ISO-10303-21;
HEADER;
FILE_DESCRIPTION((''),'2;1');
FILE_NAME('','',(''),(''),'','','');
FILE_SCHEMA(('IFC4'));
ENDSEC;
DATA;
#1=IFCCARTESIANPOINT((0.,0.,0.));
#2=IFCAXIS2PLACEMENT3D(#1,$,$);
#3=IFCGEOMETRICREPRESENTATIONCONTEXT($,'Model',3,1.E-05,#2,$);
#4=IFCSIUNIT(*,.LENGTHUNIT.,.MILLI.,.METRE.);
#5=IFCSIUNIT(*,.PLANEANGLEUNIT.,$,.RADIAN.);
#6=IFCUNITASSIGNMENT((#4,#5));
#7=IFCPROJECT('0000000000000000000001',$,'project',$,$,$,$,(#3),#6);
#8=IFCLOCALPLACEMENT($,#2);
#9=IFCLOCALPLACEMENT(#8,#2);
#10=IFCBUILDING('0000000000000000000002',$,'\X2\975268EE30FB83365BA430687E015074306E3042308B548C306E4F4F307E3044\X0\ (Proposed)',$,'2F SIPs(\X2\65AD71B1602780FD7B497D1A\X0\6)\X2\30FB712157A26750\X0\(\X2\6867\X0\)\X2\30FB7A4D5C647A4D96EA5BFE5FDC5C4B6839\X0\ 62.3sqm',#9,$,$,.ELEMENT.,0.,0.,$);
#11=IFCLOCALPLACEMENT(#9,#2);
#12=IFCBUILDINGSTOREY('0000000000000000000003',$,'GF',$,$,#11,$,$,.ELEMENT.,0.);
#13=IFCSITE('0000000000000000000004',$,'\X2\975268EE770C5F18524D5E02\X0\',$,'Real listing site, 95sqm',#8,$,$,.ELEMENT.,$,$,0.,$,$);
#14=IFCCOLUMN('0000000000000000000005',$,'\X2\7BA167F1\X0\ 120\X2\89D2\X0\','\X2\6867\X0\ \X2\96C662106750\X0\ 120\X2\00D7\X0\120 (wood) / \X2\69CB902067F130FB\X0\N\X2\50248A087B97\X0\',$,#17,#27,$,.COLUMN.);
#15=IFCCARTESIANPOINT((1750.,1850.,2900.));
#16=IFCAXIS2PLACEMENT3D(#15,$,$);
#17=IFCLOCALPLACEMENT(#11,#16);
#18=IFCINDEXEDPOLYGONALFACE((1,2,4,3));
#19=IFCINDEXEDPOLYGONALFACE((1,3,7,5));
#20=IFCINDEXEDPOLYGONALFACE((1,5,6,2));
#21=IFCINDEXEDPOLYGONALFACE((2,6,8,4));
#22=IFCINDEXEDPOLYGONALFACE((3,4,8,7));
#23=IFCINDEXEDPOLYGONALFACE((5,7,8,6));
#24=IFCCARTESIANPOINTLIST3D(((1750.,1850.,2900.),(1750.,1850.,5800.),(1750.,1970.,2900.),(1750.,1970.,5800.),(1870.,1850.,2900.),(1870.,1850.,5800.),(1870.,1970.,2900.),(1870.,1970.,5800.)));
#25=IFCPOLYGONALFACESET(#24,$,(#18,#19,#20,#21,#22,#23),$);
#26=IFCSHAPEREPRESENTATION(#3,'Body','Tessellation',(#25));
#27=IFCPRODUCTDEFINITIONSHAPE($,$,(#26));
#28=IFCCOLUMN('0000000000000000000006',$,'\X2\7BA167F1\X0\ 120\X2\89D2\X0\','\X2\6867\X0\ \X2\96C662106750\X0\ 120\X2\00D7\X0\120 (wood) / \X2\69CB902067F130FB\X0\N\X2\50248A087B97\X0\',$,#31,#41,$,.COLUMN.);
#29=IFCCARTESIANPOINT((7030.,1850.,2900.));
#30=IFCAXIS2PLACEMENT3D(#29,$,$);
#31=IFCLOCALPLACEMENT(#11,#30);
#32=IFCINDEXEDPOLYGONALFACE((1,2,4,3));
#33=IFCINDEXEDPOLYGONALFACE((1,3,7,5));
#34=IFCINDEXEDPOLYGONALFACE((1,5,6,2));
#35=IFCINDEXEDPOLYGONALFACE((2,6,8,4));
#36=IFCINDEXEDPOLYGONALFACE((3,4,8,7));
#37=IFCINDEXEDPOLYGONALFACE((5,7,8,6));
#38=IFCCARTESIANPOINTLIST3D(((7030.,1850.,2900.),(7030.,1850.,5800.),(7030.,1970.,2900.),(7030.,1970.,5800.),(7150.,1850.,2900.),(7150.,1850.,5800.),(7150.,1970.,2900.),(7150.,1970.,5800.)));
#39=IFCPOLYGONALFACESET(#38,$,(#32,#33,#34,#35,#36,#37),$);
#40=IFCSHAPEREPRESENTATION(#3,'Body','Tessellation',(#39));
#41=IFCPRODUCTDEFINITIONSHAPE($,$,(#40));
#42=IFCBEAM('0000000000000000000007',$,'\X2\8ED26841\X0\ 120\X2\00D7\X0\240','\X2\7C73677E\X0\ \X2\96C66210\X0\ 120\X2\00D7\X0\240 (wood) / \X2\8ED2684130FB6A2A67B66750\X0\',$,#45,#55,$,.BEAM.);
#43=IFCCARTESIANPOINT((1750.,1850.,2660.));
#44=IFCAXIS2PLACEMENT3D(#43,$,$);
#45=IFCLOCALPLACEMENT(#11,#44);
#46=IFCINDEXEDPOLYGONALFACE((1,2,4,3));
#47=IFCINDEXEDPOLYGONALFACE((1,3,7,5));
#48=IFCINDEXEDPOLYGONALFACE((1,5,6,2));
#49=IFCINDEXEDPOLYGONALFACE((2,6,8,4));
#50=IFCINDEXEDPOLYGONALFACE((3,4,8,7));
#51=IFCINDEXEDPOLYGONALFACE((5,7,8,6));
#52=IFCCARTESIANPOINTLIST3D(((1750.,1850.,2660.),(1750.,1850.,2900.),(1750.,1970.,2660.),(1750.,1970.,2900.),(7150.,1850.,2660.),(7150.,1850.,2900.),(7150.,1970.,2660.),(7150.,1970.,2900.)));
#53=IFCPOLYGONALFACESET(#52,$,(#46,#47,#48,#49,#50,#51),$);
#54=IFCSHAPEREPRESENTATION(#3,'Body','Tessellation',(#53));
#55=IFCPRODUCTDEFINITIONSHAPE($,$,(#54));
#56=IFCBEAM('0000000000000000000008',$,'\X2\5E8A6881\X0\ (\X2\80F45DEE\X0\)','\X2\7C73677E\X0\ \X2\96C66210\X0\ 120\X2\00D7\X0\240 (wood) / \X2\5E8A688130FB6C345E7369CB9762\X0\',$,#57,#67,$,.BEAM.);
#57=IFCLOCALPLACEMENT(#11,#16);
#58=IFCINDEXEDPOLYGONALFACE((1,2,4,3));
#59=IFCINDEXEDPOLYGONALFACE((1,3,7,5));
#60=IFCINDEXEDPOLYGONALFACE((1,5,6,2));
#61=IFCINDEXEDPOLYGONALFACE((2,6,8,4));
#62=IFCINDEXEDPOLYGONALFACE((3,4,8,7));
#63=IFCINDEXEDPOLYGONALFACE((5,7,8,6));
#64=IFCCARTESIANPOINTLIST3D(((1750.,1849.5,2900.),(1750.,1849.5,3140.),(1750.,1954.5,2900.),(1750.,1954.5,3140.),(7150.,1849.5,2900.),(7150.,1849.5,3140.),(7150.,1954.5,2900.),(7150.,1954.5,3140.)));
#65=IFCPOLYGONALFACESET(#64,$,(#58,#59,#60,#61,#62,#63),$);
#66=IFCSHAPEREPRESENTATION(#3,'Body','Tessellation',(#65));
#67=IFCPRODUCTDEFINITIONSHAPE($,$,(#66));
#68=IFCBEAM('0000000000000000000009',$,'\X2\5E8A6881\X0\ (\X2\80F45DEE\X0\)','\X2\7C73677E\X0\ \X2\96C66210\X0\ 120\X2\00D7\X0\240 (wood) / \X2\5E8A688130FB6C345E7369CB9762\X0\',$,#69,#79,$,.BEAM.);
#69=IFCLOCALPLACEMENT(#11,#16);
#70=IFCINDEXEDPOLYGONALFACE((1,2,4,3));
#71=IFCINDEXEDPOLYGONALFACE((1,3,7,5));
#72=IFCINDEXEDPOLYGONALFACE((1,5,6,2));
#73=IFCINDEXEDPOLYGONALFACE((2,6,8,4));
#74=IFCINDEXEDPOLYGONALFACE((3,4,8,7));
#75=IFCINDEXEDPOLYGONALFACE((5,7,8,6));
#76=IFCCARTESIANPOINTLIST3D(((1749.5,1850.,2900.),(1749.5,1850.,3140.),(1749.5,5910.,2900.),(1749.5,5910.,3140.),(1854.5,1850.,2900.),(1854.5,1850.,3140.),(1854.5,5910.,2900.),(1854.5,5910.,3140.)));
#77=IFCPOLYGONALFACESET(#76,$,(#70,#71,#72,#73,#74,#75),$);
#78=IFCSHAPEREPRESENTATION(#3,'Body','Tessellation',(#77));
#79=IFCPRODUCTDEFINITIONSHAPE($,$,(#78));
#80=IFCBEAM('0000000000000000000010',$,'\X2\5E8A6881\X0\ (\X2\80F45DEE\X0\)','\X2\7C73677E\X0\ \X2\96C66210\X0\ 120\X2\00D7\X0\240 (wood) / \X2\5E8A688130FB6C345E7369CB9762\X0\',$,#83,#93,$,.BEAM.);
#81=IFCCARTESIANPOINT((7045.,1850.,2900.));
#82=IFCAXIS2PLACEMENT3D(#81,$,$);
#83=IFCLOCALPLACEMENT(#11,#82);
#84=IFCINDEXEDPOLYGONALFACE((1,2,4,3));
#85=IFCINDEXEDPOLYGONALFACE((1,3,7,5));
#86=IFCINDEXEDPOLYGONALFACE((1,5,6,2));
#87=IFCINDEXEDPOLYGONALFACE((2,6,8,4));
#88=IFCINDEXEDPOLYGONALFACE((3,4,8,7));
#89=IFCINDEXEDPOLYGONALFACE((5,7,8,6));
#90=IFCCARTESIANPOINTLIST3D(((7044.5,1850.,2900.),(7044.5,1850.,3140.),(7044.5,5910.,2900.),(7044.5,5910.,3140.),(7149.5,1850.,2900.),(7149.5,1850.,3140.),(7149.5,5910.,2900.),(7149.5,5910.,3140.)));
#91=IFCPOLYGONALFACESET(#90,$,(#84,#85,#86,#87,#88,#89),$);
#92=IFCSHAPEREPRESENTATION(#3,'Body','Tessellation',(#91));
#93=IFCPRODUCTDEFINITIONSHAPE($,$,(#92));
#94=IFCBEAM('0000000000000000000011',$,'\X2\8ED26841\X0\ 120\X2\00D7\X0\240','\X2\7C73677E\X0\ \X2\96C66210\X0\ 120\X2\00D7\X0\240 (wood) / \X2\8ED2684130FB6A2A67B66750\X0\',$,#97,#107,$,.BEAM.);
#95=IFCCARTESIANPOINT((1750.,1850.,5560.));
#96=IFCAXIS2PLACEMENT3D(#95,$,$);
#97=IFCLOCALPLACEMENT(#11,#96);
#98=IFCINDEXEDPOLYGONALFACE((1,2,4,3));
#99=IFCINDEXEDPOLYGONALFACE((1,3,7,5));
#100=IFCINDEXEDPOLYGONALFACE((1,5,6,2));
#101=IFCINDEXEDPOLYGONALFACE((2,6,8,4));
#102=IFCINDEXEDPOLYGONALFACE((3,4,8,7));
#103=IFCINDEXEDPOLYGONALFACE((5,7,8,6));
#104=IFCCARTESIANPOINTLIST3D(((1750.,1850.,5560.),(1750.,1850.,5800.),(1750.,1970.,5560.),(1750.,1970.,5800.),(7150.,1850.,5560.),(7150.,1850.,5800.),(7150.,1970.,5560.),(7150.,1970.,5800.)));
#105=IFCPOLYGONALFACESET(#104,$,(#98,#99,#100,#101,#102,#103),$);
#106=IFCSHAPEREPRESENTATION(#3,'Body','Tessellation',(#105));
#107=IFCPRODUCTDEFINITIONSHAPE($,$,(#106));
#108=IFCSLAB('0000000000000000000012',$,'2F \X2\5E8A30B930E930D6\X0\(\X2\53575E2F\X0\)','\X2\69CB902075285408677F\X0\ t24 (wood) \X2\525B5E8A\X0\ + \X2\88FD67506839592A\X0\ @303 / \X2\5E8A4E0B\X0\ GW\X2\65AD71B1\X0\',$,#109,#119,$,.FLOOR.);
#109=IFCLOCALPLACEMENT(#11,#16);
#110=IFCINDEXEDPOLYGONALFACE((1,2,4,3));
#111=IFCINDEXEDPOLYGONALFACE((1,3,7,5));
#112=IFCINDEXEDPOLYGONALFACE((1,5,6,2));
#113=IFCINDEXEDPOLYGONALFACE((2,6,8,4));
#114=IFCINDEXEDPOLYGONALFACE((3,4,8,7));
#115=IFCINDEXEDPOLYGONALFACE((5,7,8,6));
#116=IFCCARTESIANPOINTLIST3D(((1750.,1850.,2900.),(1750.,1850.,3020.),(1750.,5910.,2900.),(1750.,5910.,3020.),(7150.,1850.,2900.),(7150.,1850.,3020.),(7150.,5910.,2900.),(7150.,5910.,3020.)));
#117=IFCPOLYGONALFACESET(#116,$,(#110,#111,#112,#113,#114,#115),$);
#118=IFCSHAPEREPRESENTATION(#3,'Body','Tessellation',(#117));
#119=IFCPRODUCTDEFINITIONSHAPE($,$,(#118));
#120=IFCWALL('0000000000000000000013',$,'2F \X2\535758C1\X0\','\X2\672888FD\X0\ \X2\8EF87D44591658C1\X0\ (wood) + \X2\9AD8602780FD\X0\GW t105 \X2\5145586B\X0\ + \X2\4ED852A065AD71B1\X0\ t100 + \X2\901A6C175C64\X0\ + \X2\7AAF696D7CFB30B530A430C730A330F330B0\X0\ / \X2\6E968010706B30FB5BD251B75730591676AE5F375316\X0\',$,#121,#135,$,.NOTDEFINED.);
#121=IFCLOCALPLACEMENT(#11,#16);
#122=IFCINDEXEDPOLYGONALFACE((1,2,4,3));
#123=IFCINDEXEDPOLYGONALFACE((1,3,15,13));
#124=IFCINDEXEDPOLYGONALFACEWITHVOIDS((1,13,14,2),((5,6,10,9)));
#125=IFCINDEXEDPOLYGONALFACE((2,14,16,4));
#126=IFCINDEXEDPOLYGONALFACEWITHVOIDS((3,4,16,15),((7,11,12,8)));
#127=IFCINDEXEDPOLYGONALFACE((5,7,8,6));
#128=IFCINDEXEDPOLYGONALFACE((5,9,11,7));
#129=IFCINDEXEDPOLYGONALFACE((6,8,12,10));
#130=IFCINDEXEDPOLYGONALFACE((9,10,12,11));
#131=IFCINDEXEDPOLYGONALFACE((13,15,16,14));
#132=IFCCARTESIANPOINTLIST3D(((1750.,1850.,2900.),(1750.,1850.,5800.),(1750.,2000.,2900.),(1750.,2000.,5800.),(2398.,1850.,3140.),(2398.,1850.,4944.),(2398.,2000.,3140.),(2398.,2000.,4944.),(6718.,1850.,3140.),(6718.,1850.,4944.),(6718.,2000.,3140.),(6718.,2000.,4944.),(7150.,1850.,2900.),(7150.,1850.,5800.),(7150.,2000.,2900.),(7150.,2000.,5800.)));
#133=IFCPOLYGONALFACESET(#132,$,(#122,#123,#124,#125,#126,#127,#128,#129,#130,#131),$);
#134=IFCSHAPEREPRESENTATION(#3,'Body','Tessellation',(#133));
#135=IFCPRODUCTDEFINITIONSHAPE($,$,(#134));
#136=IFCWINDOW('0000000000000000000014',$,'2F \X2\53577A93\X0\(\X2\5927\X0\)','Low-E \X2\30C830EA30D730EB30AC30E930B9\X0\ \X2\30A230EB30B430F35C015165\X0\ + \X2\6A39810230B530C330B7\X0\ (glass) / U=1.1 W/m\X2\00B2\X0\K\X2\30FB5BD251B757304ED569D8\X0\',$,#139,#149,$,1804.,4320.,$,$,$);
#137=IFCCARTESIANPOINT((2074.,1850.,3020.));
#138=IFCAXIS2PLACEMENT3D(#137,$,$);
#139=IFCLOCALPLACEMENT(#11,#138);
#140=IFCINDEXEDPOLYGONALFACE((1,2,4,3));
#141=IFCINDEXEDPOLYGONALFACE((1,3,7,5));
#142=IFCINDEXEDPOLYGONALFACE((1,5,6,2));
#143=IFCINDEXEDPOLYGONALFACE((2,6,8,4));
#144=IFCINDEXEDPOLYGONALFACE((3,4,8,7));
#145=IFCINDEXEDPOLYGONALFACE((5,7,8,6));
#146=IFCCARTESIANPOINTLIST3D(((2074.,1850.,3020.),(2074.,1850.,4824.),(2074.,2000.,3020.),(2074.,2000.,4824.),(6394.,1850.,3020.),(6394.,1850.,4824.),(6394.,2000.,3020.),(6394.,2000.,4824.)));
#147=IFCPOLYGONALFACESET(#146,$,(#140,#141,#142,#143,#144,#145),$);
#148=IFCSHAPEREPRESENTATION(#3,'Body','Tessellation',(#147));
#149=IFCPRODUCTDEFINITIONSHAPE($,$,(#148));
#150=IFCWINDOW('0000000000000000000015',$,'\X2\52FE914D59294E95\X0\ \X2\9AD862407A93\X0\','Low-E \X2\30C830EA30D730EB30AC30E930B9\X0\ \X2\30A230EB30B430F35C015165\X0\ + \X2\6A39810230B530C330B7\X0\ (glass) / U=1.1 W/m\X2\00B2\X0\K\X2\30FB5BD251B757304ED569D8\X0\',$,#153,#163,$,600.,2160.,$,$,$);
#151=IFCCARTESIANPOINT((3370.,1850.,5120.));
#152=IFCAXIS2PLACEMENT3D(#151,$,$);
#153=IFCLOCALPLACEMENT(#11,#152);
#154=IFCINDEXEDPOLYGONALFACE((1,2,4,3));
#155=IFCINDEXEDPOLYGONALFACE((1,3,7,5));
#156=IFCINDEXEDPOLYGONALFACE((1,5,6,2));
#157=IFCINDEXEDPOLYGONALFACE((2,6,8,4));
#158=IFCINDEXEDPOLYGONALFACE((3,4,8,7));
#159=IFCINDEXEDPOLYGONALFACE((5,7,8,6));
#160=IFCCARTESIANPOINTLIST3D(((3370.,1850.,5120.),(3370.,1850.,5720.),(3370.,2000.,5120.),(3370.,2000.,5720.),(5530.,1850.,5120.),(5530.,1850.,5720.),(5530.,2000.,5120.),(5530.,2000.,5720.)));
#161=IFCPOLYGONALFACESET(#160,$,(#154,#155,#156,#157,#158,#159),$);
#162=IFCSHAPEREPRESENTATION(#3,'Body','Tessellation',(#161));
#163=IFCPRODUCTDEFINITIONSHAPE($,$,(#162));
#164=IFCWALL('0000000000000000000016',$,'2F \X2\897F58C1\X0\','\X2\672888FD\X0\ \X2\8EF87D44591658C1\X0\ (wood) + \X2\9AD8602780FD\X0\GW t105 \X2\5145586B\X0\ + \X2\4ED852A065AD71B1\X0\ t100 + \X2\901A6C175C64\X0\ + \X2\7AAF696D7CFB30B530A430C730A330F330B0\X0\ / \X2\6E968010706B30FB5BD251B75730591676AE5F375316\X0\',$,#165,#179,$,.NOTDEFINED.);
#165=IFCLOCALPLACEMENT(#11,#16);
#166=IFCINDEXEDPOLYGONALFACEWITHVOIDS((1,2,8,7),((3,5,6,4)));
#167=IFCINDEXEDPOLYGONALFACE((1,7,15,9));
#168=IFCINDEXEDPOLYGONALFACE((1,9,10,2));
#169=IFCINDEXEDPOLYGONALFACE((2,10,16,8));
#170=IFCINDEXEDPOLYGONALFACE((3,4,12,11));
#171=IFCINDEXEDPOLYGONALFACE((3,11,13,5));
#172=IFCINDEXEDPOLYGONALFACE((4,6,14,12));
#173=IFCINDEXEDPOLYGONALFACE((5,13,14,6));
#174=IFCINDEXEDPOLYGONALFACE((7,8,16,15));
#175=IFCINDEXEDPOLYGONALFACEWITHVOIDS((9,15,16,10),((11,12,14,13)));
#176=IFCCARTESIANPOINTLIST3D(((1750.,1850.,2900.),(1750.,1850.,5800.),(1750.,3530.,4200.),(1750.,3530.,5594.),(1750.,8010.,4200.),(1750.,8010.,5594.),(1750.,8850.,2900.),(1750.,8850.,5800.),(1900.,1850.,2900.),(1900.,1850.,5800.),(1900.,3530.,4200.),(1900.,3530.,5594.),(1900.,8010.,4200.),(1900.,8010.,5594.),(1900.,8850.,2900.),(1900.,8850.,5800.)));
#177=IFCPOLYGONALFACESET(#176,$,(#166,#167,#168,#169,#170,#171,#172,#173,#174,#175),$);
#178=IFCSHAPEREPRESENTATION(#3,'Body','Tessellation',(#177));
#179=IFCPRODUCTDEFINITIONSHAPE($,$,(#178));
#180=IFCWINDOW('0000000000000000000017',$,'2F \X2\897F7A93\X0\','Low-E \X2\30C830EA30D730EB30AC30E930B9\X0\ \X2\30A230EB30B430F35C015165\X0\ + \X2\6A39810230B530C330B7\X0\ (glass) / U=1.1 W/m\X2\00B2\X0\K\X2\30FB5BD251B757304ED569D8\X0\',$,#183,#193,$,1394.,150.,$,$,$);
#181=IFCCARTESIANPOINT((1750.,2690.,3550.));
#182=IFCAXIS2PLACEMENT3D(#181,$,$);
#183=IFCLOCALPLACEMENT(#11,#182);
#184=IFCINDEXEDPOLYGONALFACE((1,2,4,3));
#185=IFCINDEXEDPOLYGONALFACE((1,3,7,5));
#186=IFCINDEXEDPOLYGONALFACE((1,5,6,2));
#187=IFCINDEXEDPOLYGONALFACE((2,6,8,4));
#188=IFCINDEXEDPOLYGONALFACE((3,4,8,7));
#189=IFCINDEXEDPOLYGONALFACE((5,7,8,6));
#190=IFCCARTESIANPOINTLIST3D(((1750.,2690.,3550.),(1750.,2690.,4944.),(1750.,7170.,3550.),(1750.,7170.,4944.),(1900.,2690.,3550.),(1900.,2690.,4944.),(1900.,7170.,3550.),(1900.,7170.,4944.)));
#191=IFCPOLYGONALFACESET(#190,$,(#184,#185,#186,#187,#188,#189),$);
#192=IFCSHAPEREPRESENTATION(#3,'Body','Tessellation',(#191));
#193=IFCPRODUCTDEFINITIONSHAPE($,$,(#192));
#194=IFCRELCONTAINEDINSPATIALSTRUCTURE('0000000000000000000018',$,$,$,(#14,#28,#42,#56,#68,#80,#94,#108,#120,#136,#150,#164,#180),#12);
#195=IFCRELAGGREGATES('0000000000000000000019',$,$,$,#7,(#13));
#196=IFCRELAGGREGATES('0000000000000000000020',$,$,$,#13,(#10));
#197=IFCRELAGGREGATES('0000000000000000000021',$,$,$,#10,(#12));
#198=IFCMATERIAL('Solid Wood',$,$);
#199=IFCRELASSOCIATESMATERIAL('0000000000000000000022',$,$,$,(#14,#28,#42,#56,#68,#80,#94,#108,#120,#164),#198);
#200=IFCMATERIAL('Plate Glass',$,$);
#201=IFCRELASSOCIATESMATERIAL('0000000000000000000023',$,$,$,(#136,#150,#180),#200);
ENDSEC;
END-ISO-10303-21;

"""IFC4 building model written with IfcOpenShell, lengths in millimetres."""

from ifc_helpers import new_model, si_unit, frame, frame_2d, origin, place, context, project, spatial, rectangle, extrude, material, element, fill, save


model = new_model("IFC4")

# Units and contexts
model_context = context("Model", 3, precision=1e-05, world=origin())
ifc_project = project(units=[si_unit("LENGTHUNIT", "METRE", prefix="MILLI"), si_unit("PLANEANGLEUNIT", "RADIAN")], contexts=[model_context])

# Site, building, storey
site_placement = place(None, origin())
site = spatial("IfcSite", under=ifc_project, at=site_placement, Name="青森県弘前市", ObjectType="Real listing site, 95sqm", CompositionType="ELEMENT", RefElevation=0.0)
building_placement = place(site_placement, origin())
building = spatial("IfcBuilding", under=site, at=building_placement, Name="青森・茶室と縁側のある和の住まい (Proposed)", ObjectType="2F SIPs(断熱性能等級6)・無垢材(桧)・積層積雪対応屋根 62.3sqm", CompositionType="ELEMENT", ElevationOfRefHeight=0.0, ElevationOfTerrain=0.0)
storey_placement = place(building_placement, origin())
storey = spatial("IfcBuildingStorey", under=building, at=storey_placement, Name="GF", CompositionType="ELEMENT", Elevation=0.0)

# Columns
ifc_material_1 = material(Name="Solid Wood")
column_1_placement = place(storey_placement, frame((1750.0, 1850.0, 2900.0)))
element("IfcColumn", 1, at=column_1_placement, inside=storey, material=ifc_material_1, Name="管柱 120角", Description="桧 集成材 120×120 (wood) / 構造柱・N値計算", PredefinedType="COLUMN", context=model_context, shape_type="SweptSolid", body=[
    extrude(rectangle(XDim=120.0, YDim=120.0, at=frame_2d((60.0, 60.0))), frame((1750.0, 1850.0, 2900.0)), (0.0, 0.0, 1.0), 2900.0),
])
column_2_placement = place(storey_placement, frame((7030.0, 1850.0, 2900.0)))
element("IfcColumn", 2, at=column_2_placement, inside=storey, material=ifc_material_1, Name="管柱 120角", Description="桧 集成材 120×120 (wood) / 構造柱・N値計算", PredefinedType="COLUMN", context=model_context, shape_type="SweptSolid", body=[
    extrude(rectangle(XDim=120.0, YDim=120.0, at=frame_2d((60.0, 60.0))), frame((7030.0, 1850.0, 2900.0)), (0.0, 0.0, 1.0), 2900.0),
])

# Beams
beam_1_placement = place(storey_placement, frame((1750.0, 1850.0, 2660.0)))
element("IfcBeam", 3, at=beam_1_placement, inside=storey, material=ifc_material_1, Name="軒桁 120×240", Description="米松 集成 120×240 (wood) / 軒桁・横架材", PredefinedType="BEAM", context=model_context, shape_type="SweptSolid", body=[
    extrude(rectangle(XDim=5400.0, YDim=120.0, at=frame_2d((2700.0, 60.0))), frame((1750.0, 1850.0, 2660.0)), (0.0, 0.0, 1.0), 240.0),
])
beam_2_placement = place(storey_placement, frame((1750.0, 1850.0, 2900.0)))
element("IfcBeam", 4, at=beam_2_placement, inside=storey, material=ifc_material_1, Name="床梁 (胴差)", Description="米松 集成 120×240 (wood) / 床梁・水平構面", PredefinedType="BEAM", context=model_context, shape_type="SweptSolid", body=[
    extrude(rectangle(XDim=5400.0, YDim=105.0, at=frame_2d((2700.0, 52.0))), frame((1750.0, 1850.0, 2900.0)), (0.0, 0.0, 1.0), 240.0),
])
beam_3_placement = place(storey_placement, frame((1750.0, 1850.0, 2900.0)))
element("IfcBeam", 5, at=beam_3_placement, inside=storey, material=ifc_material_1, Name="床梁 (胴差)", Description="米松 集成 120×240 (wood) / 床梁・水平構面", PredefinedType="BEAM", context=model_context, shape_type="SweptSolid", body=[
    extrude(rectangle(XDim=105.0, YDim=4060.0, at=frame_2d((52.0, 2030.0))), frame((1750.0, 1850.0, 2900.0)), (0.0, 0.0, 1.0), 240.0),
])
beam_4_placement = place(storey_placement, frame((7045.0, 1850.0, 2900.0)))
element("IfcBeam", 6, at=beam_4_placement, inside=storey, material=ifc_material_1, Name="床梁 (胴差)", Description="米松 集成 120×240 (wood) / 床梁・水平構面", PredefinedType="BEAM", context=model_context, shape_type="SweptSolid", body=[
    extrude(rectangle(XDim=105.0, YDim=4060.0, at=frame_2d((52.0, 2030.0))), frame((7045.0, 1850.0, 2900.0)), (0.0, 0.0, 1.0), 240.0),
])
beam_5_placement = place(storey_placement, frame((1750.0, 1850.0, 5560.0)))
element("IfcBeam", 7, at=beam_5_placement, inside=storey, material=ifc_material_1, Name="軒桁 120×240", Description="米松 集成 120×240 (wood) / 軒桁・横架材", PredefinedType="BEAM", context=model_context, shape_type="SweptSolid", body=[
    extrude(rectangle(XDim=5400.0, YDim=120.0, at=frame_2d((2700.0, 60.0))), frame((1750.0, 1850.0, 5560.0)), (0.0, 0.0, 1.0), 240.0),
])

# Slab
slab_placement = place(storey_placement, frame((1750.0, 1850.0, 2900.0)))
element("IfcSlab", 8, at=slab_placement, inside=storey, material=ifc_material_1, Name="2F 床スラブ(南帯)", Description="構造用合板 t24 (wood) 剛床 + 製材根太 @303 / 床下 GW断熱", PredefinedType="FLOOR", context=model_context, shape_type="SweptSolid", body=[
    extrude(rectangle(XDim=5400.0, YDim=4060.0, at=frame_2d((2700.0, 2030.0))), frame((1750.0, 1850.0, 2900.0)), (0.0, 0.0, 1.0), 120.0),
])

# Wall, openings, windows
wall_1_placement = place(storey_placement, frame((1750.0, 1850.0, 2900.0)))
wall_1 = element("IfcWall", 9, at=wall_1_placement, inside=storey, material=ifc_material_1, Name="2F 南壁", Description="木製 軸組外壁 (wood) + 高性能GW t105 充填 + 付加断熱 t100 + 通気層 + 窯業系サイディング / 準耐火・寒冷地外皮強化", PredefinedType="NOTDEFINED", context=model_context, shape_type="SweptSolid", body=[
    extrude(rectangle(XDim=5400.0, YDim=150.0, at=frame_2d((2700.0, 75.0))), frame((1750.0, 1850.0, 2900.0)), (0.0, 0.0, 1.0), 2900.0),
])
opening_1_placement = place(storey_placement, frame((2074.0, 1850.0, 3020.0)))
opening_1 = element("IfcOpeningElement", 10, at=opening_1_placement, cuts=wall_1, PredefinedType="NOTDEFINED", context=model_context, shape_type="SweptSolid", body=[
    extrude(rectangle(XDim=4320.0, YDim=150.0, at=frame_2d((2160.0, 75.0))), frame((2074.0, 1850.0, 3020.0)), (0.0, 0.0, 1.0), 1804.0),
])
opening_2_placement = place(storey_placement, frame((3370.0, 1850.0, 5120.0)))
opening_2 = element("IfcOpeningElement", 11, at=opening_2_placement, cuts=wall_1, PredefinedType="NOTDEFINED", context=model_context, shape_type="SweptSolid", body=[
    extrude(rectangle(XDim=2160.0, YDim=150.0, at=frame_2d((1080.0, 75.0))), frame((3370.0, 1850.0, 5120.0)), (0.0, 0.0, 1.0), 600.0),
])
ifc_material_2 = material(Name="Plate Glass")
window_1_placement = place(storey_placement, frame((2074.0, 1850.0, 3020.0)))
window_1 = element("IfcWindow", 12, at=window_1_placement, inside=storey, material=ifc_material_2, Name="2F 南窓(大)", Description="Low-E トリプルガラス アルゴン封入 + 樹脂サッシ (glass) / U=1.1 W/m²K・寒冷地仕様", OverallHeight=1804.0, OverallWidth=4320.0, context=model_context, shape_type="SweptSolid", body=[
    extrude(rectangle(XDim=4320.0, YDim=150.0, at=frame_2d((2160.0, 75.0))), frame((2074.0, 1850.0, 3020.0)), (0.0, 0.0, 1.0), 1804.0),
])
fill(opening_1, window_1)
window_2_placement = place(storey_placement, frame((3370.0, 1850.0, 5120.0)))
window_2 = element("IfcWindow", 13, at=window_2_placement, inside=storey, material=ifc_material_2, Name="勾配天井 高所窓", Description="Low-E トリプルガラス アルゴン封入 + 樹脂サッシ (glass) / U=1.1 W/m²K・寒冷地仕様", OverallHeight=600.0, OverallWidth=2160.0, context=model_context, shape_type="SweptSolid", body=[
    extrude(rectangle(XDim=2160.0, YDim=150.0, at=frame_2d((1080.0, 75.0))), frame((3370.0, 1850.0, 5120.0)), (0.0, 0.0, 1.0), 600.0),
])
fill(opening_2, window_2)

# Wall, opening, window
wall_2_placement = place(storey_placement, frame((1750.0, 1850.0, 2900.0)))
wall_2 = element("IfcWall", 14, at=wall_2_placement, inside=storey, material=ifc_material_1, Name="2F 西壁", Description="木製 軸組外壁 (wood) + 高性能GW t105 充填 + 付加断熱 t100 + 通気層 + 窯業系サイディング / 準耐火・寒冷地外皮強化", PredefinedType="NOTDEFINED", context=model_context, shape_type="SweptSolid", body=[
    extrude(rectangle(XDim=150.0, YDim=7000.0, at=frame_2d((75.0, 3500.0))), frame((1750.0, 1850.0, 2900.0)), (0.0, 0.0, 1.0), 2900.0),
])
opening_3_placement = place(storey_placement, frame((1750.0, 2690.0, 3550.0)))
opening_3 = element("IfcOpeningElement", 15, at=opening_3_placement, cuts=wall_2, PredefinedType="NOTDEFINED", context=model_context, shape_type="SweptSolid", body=[
    extrude(rectangle(XDim=150.0, YDim=4480.0, at=frame_2d((75.0, 2240.0))), frame((1750.0, 2690.0, 3550.0)), (0.0, 0.0, 1.0), 1394.0),
])
window_3_placement = place(storey_placement, frame((1750.0, 2690.0, 3550.0)))
window_3 = element("IfcWindow", 16, at=window_3_placement, inside=storey, material=ifc_material_2, Name="2F 西窓", Description="Low-E トリプルガラス アルゴン封入 + 樹脂サッシ (glass) / U=1.1 W/m²K・寒冷地仕様", OverallHeight=1394.0, OverallWidth=150.0, context=model_context, shape_type="SweptSolid", body=[
    extrude(rectangle(XDim=150.0, YDim=4480.0, at=frame_2d((75.0, 2240.0))), frame((1750.0, 2690.0, 3550.0)), (0.0, 0.0, 1.0), 1394.0),
])
fill(opening_3, window_3)

save(model, "model.ifc")
